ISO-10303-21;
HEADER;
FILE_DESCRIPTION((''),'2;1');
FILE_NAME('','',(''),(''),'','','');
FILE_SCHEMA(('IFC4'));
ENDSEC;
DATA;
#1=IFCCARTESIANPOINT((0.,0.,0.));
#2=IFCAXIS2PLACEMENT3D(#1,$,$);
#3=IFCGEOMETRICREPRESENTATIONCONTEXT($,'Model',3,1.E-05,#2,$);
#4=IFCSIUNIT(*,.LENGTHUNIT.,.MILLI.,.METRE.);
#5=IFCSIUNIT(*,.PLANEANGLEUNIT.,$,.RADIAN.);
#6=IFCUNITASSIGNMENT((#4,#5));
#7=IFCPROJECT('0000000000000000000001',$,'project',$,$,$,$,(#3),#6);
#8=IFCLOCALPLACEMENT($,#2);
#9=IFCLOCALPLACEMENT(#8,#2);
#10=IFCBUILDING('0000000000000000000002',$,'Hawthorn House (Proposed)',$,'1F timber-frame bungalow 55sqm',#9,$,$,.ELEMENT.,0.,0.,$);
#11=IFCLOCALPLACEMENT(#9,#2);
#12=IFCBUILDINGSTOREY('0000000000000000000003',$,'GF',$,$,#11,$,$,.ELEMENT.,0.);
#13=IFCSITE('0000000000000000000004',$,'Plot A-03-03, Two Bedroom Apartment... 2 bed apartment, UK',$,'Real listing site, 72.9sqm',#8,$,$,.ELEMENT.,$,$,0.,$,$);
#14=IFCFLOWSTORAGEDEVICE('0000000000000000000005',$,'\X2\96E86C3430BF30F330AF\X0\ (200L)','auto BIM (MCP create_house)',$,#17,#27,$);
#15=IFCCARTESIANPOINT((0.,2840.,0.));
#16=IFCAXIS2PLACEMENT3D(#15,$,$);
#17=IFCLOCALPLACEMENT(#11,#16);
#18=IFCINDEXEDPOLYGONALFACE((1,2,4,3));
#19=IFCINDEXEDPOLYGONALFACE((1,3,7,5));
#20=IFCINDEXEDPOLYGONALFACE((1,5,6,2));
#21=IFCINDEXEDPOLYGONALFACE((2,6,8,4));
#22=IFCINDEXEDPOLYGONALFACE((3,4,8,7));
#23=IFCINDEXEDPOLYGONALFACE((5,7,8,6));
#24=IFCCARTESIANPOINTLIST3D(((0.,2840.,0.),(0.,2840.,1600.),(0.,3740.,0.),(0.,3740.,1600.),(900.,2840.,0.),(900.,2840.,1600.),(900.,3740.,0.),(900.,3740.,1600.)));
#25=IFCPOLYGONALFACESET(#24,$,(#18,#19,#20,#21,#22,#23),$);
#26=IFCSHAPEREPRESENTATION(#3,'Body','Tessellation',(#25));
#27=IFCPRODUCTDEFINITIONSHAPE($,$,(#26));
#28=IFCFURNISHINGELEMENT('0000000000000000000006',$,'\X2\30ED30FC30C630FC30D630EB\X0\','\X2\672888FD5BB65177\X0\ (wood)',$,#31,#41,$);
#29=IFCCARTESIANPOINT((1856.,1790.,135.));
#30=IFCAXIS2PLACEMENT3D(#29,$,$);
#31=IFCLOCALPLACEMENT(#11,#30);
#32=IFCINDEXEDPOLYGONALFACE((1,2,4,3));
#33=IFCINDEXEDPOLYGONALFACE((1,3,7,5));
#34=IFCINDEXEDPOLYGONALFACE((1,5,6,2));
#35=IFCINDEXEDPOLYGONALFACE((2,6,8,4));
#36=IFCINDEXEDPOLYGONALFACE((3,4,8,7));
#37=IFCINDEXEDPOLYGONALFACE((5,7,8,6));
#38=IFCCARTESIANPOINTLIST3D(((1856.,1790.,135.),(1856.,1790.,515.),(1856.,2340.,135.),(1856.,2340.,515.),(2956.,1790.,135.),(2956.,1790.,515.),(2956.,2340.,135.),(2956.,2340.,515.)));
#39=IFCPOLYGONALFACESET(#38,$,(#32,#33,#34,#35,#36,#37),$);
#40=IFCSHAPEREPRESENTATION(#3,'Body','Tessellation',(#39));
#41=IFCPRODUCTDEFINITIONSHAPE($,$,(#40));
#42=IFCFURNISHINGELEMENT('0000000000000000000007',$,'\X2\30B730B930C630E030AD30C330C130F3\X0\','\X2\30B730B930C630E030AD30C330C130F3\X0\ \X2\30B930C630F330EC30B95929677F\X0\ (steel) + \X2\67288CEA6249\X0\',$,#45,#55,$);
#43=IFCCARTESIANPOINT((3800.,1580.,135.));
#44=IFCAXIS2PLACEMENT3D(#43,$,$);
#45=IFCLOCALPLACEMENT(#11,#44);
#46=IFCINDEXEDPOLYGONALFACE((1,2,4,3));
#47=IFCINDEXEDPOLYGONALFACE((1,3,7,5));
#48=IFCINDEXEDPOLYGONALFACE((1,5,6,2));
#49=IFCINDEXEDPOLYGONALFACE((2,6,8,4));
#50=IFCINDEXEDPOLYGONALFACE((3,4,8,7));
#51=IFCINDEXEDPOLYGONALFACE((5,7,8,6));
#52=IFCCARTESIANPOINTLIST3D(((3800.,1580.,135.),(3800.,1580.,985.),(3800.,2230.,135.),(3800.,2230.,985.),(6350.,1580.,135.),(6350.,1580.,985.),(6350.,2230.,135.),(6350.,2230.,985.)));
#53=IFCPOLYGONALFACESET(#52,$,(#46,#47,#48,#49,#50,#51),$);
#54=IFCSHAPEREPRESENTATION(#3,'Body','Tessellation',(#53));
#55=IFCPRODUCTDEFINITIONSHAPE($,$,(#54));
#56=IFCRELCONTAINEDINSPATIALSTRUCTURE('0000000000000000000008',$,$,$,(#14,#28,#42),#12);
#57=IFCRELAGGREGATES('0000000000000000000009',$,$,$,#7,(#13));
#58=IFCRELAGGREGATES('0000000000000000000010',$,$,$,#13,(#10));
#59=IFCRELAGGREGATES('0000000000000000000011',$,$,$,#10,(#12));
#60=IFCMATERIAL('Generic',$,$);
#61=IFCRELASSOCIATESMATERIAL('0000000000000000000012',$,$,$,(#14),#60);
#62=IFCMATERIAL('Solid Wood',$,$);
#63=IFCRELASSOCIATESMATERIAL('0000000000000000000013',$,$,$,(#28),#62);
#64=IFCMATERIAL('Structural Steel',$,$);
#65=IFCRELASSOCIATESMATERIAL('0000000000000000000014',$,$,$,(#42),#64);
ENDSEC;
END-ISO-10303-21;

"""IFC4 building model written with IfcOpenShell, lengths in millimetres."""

from ifc_helpers import new_model, si_unit, frame, frame_2d, origin, place, context, project, spatial, rectangle, extrude, material, element, save


model = new_model("IFC4")

# Units and contexts
model_context = context("Model", 3, precision=1e-05, world=origin())
ifc_project = project(units=[si_unit("LENGTHUNIT", "METRE", prefix="MILLI"), si_unit("PLANEANGLEUNIT", "RADIAN")], contexts=[model_context])

# Site, building, storey
site_placement = place(None, origin())
site = spatial("IfcSite", under=ifc_project, at=site_placement, Name="Plot A-03-03, Two Bedroom Apartment... 2 bed apartment, UK", ObjectType="Real listing site, 72.9sqm", CompositionType="ELEMENT", RefElevation=0.0)
building_placement = place(site_placement, origin())
building = spatial("IfcBuilding", under=site, at=building_placement, Name="Hawthorn House (Proposed)", ObjectType="1F timber-frame bungalow 55sqm", CompositionType="ELEMENT", ElevationOfRefHeight=0.0, ElevationOfTerrain=0.0)
storey_placement = place(building_placement, origin())
storey = spatial("IfcBuildingStorey", under=building, at=storey_placement, Name="GF", CompositionType="ELEMENT", Elevation=0.0)

# Shared definitions
ifc_material_1 = material(Name="Solid Wood")

# Shared definitions
ifc_material_2 = material(Name="Generic")

# Flow storage device
flow_storage_device_placement = place(storey_placement, frame((0.0, 2840.0, 0.0)))
element("IfcFlowStorageDevice", 1, at=flow_storage_device_placement, inside=storey, material=ifc_material_2, Name="雨水タンク (200L)", Description="auto BIM (MCP create_house)", context=model_context, shape_type="SweptSolid", body=[
    extrude(rectangle(XDim=900.0, YDim=900.0, at=frame_2d((450.0, 450.0))), frame((0.0, 2840.0, 0.0)), (0.0, 0.0, 1.0), 1600.0),
])

# Furnishing elements
furnishing_1_placement = place(storey_placement, frame((1856.0, 1790.0, 135.0)))
element("IfcFurnishingElement", 2, at=furnishing_1_placement, inside=storey, material=ifc_material_1, Name="ローテーブル", Description="木製家具 (wood)", context=model_context, shape_type="SweptSolid", body=[
    extrude(rectangle(XDim=1100.0, YDim=550.0, at=frame_2d((550.0, 275.0))), frame((1856.0, 1790.0, 135.0)), (0.0, 0.0, 1.0), 380.0),
])
ifc_material_3 = material(Name="Structural Steel")
furnishing_2_placement = place(storey_placement, frame((3800.0, 1580.0, 135.0)))
element("IfcFurnishingElement", 3, at=furnishing_2_placement, inside=storey, material=ifc_material_3, Name="システムキッチン", Description="システムキッチン ステンレス天板 (steel) + 木質扉", context=model_context, shape_type="SweptSolid", body=[
    extrude(rectangle(XDim=2550.0, YDim=650.0, at=frame_2d((1275.0, 325.0))), frame((3800.0, 1580.0, 135.0)), (0.0, 0.0, 1.0), 850.0),
])

save(model, "model.ifc")
